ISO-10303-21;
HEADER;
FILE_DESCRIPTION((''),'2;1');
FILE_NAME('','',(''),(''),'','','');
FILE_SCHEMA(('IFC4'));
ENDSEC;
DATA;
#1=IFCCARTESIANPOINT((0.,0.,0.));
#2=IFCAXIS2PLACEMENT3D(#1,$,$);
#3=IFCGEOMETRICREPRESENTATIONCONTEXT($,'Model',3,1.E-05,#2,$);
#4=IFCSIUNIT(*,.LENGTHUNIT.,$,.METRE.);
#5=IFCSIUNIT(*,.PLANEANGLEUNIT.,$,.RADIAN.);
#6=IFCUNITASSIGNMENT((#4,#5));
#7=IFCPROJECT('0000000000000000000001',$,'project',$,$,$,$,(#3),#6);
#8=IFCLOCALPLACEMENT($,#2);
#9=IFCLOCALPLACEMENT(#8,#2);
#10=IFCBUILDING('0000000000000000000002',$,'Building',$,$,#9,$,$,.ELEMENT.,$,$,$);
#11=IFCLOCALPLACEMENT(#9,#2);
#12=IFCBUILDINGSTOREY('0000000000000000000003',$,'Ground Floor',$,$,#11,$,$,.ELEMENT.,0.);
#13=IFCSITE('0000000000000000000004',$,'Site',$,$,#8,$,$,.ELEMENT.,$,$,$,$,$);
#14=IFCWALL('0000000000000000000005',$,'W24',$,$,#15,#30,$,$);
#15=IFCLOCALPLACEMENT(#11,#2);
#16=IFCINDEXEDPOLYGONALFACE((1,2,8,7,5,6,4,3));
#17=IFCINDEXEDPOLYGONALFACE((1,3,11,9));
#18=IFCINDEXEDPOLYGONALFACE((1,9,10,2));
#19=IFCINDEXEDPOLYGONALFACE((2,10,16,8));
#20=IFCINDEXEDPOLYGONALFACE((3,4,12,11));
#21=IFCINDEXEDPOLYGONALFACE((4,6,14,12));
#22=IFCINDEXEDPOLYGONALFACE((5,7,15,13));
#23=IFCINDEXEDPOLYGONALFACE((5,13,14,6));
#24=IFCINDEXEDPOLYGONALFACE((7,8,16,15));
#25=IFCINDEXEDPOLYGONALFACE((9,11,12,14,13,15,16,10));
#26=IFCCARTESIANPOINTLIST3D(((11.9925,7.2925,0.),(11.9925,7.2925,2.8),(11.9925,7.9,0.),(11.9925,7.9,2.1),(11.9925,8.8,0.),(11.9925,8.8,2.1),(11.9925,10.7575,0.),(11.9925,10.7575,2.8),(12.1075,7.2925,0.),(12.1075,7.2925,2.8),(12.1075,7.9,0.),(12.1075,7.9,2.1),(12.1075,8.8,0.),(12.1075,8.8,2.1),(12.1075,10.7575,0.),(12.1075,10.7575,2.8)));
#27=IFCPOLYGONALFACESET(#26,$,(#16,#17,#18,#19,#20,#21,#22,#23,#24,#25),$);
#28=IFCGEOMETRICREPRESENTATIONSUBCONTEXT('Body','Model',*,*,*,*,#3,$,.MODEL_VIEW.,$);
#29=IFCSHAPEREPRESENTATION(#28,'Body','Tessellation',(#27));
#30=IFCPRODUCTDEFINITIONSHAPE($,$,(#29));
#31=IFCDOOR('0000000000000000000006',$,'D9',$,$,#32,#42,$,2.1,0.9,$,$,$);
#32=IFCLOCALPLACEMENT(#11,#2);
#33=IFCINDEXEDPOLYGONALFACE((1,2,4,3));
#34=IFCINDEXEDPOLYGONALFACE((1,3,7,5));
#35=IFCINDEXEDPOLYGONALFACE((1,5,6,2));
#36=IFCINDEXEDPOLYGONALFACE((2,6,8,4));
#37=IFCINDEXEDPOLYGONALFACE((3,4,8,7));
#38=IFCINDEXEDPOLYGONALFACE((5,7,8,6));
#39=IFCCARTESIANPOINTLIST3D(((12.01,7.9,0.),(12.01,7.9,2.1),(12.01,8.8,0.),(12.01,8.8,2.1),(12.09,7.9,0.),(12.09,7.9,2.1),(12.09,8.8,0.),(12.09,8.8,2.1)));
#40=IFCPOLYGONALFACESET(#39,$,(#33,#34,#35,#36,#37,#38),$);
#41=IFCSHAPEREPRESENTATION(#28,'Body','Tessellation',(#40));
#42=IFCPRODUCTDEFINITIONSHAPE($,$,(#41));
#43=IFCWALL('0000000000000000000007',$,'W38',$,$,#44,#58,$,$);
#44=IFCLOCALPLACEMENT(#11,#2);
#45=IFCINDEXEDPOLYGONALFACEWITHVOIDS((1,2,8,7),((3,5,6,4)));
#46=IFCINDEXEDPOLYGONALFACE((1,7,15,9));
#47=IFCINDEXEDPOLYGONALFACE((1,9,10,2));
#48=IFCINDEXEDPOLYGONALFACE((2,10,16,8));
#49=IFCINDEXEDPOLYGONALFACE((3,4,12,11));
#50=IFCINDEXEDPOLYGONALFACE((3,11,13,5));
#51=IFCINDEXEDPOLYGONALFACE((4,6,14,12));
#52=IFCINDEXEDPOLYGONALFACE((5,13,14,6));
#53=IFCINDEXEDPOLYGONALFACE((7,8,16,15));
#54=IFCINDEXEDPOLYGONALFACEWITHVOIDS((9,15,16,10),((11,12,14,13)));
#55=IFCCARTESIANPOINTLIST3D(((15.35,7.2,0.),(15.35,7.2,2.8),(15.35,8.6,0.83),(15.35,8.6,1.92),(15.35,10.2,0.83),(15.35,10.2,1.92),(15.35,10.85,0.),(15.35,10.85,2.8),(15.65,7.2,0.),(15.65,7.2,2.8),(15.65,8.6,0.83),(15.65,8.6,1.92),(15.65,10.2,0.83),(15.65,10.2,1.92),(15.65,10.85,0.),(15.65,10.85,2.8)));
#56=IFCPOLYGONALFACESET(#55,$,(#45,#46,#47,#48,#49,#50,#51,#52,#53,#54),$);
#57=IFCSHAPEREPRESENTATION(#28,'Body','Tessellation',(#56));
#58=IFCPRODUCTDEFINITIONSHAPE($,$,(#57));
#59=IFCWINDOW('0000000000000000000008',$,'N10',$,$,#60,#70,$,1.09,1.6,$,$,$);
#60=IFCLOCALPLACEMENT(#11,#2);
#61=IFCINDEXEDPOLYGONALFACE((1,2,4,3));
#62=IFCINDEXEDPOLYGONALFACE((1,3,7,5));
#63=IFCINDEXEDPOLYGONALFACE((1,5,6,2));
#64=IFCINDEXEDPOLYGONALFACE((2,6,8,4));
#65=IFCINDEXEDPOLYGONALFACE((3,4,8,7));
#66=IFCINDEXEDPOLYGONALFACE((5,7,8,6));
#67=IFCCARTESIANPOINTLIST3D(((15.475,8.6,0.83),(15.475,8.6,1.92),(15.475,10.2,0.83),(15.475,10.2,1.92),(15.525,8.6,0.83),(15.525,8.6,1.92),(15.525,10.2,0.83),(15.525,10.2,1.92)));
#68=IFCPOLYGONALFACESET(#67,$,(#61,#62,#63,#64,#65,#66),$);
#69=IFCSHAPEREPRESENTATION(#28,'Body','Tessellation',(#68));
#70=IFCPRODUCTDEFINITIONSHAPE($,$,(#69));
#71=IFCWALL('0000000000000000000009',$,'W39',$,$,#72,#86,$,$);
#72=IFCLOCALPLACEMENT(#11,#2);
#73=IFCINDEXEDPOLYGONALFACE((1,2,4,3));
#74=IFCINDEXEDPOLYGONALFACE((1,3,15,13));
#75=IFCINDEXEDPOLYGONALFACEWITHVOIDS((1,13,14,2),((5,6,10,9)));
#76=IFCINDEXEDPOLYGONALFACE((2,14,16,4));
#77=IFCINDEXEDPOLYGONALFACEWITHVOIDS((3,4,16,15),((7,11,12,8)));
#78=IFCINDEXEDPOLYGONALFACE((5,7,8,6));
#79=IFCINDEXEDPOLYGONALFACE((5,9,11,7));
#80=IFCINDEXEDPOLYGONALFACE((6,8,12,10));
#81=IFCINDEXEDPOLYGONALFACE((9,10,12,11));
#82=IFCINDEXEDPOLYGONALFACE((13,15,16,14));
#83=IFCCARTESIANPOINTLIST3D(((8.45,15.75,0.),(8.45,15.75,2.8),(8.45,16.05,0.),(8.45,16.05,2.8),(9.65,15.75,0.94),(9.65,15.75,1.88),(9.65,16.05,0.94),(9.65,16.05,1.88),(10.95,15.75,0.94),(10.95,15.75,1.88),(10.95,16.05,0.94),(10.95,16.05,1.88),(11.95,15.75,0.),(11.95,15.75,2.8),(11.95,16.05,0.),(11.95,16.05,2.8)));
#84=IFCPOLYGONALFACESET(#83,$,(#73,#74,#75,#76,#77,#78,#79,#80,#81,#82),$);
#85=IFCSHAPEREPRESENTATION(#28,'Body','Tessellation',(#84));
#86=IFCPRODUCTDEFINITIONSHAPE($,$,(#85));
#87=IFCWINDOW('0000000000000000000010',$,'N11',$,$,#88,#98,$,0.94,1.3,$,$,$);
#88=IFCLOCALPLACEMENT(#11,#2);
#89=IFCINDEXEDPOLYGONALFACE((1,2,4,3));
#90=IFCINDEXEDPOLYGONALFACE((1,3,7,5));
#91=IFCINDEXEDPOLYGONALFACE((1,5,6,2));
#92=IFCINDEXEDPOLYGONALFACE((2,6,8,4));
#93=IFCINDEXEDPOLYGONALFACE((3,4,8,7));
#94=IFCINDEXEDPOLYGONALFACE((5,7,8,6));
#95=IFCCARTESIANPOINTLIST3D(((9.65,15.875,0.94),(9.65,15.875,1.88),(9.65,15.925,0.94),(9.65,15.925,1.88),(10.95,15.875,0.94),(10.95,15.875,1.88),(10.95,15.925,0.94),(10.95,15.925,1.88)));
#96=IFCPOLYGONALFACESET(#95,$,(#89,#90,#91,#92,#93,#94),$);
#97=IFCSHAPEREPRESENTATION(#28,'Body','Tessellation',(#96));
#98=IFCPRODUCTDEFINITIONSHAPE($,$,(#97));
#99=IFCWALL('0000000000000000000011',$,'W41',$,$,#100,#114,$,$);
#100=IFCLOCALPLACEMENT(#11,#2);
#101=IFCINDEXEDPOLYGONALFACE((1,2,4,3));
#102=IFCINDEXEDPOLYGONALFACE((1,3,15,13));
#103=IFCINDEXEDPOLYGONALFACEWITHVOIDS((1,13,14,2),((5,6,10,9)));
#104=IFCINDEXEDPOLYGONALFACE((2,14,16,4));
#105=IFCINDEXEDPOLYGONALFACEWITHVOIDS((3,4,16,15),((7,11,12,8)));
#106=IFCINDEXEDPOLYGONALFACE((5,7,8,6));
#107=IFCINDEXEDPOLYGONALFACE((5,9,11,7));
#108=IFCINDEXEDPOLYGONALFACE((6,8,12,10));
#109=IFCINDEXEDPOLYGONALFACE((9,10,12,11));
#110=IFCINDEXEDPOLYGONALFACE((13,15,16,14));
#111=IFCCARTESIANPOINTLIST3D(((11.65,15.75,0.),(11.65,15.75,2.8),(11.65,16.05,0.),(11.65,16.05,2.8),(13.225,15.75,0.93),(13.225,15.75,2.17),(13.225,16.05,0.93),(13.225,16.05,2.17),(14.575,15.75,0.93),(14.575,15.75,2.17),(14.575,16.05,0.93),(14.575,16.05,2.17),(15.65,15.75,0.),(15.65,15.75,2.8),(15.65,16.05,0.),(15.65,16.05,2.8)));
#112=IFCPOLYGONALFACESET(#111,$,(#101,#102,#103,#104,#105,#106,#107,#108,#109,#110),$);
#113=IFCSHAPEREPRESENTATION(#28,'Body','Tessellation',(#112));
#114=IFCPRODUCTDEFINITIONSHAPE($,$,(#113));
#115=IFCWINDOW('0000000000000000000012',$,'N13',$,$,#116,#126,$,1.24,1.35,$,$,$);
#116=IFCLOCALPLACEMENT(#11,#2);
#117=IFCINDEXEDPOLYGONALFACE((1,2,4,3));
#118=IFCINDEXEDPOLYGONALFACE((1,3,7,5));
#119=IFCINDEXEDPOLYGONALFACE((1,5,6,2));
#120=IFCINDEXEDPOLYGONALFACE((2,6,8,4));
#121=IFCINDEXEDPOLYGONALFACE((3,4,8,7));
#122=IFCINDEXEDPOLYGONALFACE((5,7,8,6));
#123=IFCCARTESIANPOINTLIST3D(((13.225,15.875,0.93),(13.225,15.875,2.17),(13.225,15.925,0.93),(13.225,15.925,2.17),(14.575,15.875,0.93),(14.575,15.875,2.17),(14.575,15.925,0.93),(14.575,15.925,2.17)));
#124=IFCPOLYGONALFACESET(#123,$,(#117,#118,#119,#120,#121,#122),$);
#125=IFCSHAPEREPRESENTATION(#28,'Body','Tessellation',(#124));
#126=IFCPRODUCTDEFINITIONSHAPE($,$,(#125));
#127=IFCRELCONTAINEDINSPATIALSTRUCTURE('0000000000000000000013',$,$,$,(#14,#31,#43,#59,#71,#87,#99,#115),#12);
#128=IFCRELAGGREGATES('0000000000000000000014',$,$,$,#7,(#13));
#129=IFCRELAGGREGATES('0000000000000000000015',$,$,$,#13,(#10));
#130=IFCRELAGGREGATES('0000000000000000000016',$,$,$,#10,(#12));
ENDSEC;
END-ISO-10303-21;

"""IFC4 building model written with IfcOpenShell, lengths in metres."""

from ifc_helpers import new_model, si_unit, frame, frame_2d, origin, origin_2d, place, context, subcontext, project, spatial, rectangle, extrude, element, fill, save


model = new_model("IFC4")

# Units and contexts
model_context = context("Model", 3, precision=1e-05, world=origin())
body_context = subcontext(model_context, "Body", "Model", "MODEL_VIEW")
ifc_project = project(units=[si_unit("LENGTHUNIT", "METRE"), si_unit("PLANEANGLEUNIT", "RADIAN")], contexts=[model_context])

# Site, building, storey
site_placement = place(None, origin())
site = spatial("IfcSite", under=ifc_project, at=site_placement, Name="Site", CompositionType="ELEMENT")
building_placement = place(site_placement, origin())
building = spatial("IfcBuilding", under=site, at=building_placement, Name="Building", CompositionType="ELEMENT")
storey_placement = place(building_placement, origin())
storey = spatial("IfcBuildingStorey", under=building, at=storey_placement, Name="Ground Floor", CompositionType="ELEMENT", Elevation=0.0)

# Wall, opening, door
wall_1_placement = place(storey_placement, frame((12.05, 7.35, 0.0), x_axis=(0.0, 1.0, 0.0)))
wall_1 = element("IfcWall", 1, at=wall_1_placement, inside=storey, Name="W24", context=body_context, shape_type="SweptSolid", body=[
    extrude(rectangle(XDim=3.465, YDim=0.115, at=frame_2d((1.675, 0.0))), origin(), (0.0, 0.0, 1.0), 2.8),
])
opening_1_placement = place(wall_1_placement, frame((1.0, 0.0, 0.0)))
opening_1 = element("IfcOpeningElement", 2, at=opening_1_placement, cuts=wall_1, context=body_context, shape_type="SweptSolid", body=[
    extrude(rectangle(XDim=0.9, YDim=0.215, at=origin_2d()), origin(), (0.0, 0.0, 1.0), 2.1),
])
door_1_placement = place(opening_1_placement, origin())
door_1 = element("IfcDoor", 3, at=door_1_placement, inside=storey, Name="D9", OverallHeight=2.1, OverallWidth=0.9, context=body_context, shape_type="SweptSolid", body=[
    extrude(rectangle(XDim=0.9, YDim=0.08, at=origin_2d()), origin(), (0.0, 0.0, 1.0), 2.1),
])
fill(opening_1, door_1)

# Walls, openings, windows
wall_2_placement = place(storey_placement, frame((15.5, 7.35, 0.0), x_axis=(0.0, 1.0, 0.0)))
wall_2 = element("IfcWall", 4, at=wall_2_placement, inside=storey, Name="W38", context=body_context, shape_type="SweptSolid", body=[
    extrude(rectangle(XDim=3.65, YDim=0.3, at=frame_2d((1.675, 0.0))), origin(), (0.0, 0.0, 1.0), 2.8),
])
opening_2_placement = place(wall_2_placement, frame((2.05, 0.0, 0.83)))
opening_2 = element("IfcOpeningElement", 5, at=opening_2_placement, cuts=wall_2, context=body_context, shape_type="SweptSolid", body=[
    extrude(rectangle(XDim=1.6, YDim=0.4, at=origin_2d()), origin(), (0.0, 0.0, 1.0), 1.09),
])
window_1_placement = place(opening_2_placement, origin())
window_1 = element("IfcWindow", 6, at=window_1_placement, inside=storey, Name="N10", OverallHeight=1.09, OverallWidth=1.6, context=body_context, shape_type="SweptSolid", body=[
    extrude(rectangle(XDim=1.6, YDim=0.05, at=origin_2d()), origin(), (0.0, 0.0, 1.0), 1.09),
])
fill(opening_2, window_1)
wall_3_placement = place(storey_placement, frame((8.6, 15.9, 0.0), x_axis=(1.0, 0.0, 0.0)))
wall_3 = element("IfcWall", 7, at=wall_3_placement, inside=storey, Name="W39", context=body_context, shape_type="SweptSolid", body=[
    extrude(rectangle(XDim=3.5, YDim=0.3, at=frame_2d((1.6, 0.0))), origin(), (0.0, 0.0, 1.0), 2.8),
])
opening_3_placement = place(wall_3_placement, frame((1.7, 0.0, 0.94)))
opening_3 = element("IfcOpeningElement", 8, at=opening_3_placement, cuts=wall_3, context=body_context, shape_type="SweptSolid", body=[
    extrude(rectangle(XDim=1.3, YDim=0.4, at=origin_2d()), origin(), (0.0, 0.0, 1.0), 0.94),
])
window_2_placement = place(opening_3_placement, origin())
window_2 = element("IfcWindow", 9, at=window_2_placement, inside=storey, Name="N11", OverallHeight=0.94, OverallWidth=1.3, context=body_context, shape_type="SweptSolid", body=[
    extrude(rectangle(XDim=1.3, YDim=0.05, at=origin_2d()), origin(), (0.0, 0.0, 1.0), 0.94),
])
fill(opening_3, window_2)
wall_4_placement = place(storey_placement, frame((11.8, 15.9, 0.0), x_axis=(1.0, 0.0, 0.0)))
wall_4 = element("IfcWall", 10, at=wall_4_placement, inside=storey, Name="W41", context=body_context, shape_type="SweptSolid", body=[
    extrude(rectangle(XDim=4.0, YDim=0.3, at=frame_2d((1.85, 0.0))), origin(), (0.0, 0.0, 1.0), 2.8),
])
opening_4_placement = place(wall_4_placement, frame((2.1, 0.0, 0.93)))
opening_4 = element("IfcOpeningElement", 11, at=opening_4_placement, cuts=wall_4, context=body_context, shape_type="SweptSolid", body=[
    extrude(rectangle(XDim=1.35, YDim=0.4, at=origin_2d()), origin(), (0.0, 0.0, 1.0), 1.24),
])
window_3_placement = place(opening_4_placement, origin())
window_3 = element("IfcWindow", 12, at=window_3_placement, inside=storey, Name="N13", OverallHeight=1.24, OverallWidth=1.35, context=body_context, shape_type="SweptSolid", body=[
    extrude(rectangle(XDim=1.35, YDim=0.05, at=origin_2d()), origin(), (0.0, 0.0, 1.0), 1.24),
])
fill(opening_4, window_3)

save(model, "model.ifc")
